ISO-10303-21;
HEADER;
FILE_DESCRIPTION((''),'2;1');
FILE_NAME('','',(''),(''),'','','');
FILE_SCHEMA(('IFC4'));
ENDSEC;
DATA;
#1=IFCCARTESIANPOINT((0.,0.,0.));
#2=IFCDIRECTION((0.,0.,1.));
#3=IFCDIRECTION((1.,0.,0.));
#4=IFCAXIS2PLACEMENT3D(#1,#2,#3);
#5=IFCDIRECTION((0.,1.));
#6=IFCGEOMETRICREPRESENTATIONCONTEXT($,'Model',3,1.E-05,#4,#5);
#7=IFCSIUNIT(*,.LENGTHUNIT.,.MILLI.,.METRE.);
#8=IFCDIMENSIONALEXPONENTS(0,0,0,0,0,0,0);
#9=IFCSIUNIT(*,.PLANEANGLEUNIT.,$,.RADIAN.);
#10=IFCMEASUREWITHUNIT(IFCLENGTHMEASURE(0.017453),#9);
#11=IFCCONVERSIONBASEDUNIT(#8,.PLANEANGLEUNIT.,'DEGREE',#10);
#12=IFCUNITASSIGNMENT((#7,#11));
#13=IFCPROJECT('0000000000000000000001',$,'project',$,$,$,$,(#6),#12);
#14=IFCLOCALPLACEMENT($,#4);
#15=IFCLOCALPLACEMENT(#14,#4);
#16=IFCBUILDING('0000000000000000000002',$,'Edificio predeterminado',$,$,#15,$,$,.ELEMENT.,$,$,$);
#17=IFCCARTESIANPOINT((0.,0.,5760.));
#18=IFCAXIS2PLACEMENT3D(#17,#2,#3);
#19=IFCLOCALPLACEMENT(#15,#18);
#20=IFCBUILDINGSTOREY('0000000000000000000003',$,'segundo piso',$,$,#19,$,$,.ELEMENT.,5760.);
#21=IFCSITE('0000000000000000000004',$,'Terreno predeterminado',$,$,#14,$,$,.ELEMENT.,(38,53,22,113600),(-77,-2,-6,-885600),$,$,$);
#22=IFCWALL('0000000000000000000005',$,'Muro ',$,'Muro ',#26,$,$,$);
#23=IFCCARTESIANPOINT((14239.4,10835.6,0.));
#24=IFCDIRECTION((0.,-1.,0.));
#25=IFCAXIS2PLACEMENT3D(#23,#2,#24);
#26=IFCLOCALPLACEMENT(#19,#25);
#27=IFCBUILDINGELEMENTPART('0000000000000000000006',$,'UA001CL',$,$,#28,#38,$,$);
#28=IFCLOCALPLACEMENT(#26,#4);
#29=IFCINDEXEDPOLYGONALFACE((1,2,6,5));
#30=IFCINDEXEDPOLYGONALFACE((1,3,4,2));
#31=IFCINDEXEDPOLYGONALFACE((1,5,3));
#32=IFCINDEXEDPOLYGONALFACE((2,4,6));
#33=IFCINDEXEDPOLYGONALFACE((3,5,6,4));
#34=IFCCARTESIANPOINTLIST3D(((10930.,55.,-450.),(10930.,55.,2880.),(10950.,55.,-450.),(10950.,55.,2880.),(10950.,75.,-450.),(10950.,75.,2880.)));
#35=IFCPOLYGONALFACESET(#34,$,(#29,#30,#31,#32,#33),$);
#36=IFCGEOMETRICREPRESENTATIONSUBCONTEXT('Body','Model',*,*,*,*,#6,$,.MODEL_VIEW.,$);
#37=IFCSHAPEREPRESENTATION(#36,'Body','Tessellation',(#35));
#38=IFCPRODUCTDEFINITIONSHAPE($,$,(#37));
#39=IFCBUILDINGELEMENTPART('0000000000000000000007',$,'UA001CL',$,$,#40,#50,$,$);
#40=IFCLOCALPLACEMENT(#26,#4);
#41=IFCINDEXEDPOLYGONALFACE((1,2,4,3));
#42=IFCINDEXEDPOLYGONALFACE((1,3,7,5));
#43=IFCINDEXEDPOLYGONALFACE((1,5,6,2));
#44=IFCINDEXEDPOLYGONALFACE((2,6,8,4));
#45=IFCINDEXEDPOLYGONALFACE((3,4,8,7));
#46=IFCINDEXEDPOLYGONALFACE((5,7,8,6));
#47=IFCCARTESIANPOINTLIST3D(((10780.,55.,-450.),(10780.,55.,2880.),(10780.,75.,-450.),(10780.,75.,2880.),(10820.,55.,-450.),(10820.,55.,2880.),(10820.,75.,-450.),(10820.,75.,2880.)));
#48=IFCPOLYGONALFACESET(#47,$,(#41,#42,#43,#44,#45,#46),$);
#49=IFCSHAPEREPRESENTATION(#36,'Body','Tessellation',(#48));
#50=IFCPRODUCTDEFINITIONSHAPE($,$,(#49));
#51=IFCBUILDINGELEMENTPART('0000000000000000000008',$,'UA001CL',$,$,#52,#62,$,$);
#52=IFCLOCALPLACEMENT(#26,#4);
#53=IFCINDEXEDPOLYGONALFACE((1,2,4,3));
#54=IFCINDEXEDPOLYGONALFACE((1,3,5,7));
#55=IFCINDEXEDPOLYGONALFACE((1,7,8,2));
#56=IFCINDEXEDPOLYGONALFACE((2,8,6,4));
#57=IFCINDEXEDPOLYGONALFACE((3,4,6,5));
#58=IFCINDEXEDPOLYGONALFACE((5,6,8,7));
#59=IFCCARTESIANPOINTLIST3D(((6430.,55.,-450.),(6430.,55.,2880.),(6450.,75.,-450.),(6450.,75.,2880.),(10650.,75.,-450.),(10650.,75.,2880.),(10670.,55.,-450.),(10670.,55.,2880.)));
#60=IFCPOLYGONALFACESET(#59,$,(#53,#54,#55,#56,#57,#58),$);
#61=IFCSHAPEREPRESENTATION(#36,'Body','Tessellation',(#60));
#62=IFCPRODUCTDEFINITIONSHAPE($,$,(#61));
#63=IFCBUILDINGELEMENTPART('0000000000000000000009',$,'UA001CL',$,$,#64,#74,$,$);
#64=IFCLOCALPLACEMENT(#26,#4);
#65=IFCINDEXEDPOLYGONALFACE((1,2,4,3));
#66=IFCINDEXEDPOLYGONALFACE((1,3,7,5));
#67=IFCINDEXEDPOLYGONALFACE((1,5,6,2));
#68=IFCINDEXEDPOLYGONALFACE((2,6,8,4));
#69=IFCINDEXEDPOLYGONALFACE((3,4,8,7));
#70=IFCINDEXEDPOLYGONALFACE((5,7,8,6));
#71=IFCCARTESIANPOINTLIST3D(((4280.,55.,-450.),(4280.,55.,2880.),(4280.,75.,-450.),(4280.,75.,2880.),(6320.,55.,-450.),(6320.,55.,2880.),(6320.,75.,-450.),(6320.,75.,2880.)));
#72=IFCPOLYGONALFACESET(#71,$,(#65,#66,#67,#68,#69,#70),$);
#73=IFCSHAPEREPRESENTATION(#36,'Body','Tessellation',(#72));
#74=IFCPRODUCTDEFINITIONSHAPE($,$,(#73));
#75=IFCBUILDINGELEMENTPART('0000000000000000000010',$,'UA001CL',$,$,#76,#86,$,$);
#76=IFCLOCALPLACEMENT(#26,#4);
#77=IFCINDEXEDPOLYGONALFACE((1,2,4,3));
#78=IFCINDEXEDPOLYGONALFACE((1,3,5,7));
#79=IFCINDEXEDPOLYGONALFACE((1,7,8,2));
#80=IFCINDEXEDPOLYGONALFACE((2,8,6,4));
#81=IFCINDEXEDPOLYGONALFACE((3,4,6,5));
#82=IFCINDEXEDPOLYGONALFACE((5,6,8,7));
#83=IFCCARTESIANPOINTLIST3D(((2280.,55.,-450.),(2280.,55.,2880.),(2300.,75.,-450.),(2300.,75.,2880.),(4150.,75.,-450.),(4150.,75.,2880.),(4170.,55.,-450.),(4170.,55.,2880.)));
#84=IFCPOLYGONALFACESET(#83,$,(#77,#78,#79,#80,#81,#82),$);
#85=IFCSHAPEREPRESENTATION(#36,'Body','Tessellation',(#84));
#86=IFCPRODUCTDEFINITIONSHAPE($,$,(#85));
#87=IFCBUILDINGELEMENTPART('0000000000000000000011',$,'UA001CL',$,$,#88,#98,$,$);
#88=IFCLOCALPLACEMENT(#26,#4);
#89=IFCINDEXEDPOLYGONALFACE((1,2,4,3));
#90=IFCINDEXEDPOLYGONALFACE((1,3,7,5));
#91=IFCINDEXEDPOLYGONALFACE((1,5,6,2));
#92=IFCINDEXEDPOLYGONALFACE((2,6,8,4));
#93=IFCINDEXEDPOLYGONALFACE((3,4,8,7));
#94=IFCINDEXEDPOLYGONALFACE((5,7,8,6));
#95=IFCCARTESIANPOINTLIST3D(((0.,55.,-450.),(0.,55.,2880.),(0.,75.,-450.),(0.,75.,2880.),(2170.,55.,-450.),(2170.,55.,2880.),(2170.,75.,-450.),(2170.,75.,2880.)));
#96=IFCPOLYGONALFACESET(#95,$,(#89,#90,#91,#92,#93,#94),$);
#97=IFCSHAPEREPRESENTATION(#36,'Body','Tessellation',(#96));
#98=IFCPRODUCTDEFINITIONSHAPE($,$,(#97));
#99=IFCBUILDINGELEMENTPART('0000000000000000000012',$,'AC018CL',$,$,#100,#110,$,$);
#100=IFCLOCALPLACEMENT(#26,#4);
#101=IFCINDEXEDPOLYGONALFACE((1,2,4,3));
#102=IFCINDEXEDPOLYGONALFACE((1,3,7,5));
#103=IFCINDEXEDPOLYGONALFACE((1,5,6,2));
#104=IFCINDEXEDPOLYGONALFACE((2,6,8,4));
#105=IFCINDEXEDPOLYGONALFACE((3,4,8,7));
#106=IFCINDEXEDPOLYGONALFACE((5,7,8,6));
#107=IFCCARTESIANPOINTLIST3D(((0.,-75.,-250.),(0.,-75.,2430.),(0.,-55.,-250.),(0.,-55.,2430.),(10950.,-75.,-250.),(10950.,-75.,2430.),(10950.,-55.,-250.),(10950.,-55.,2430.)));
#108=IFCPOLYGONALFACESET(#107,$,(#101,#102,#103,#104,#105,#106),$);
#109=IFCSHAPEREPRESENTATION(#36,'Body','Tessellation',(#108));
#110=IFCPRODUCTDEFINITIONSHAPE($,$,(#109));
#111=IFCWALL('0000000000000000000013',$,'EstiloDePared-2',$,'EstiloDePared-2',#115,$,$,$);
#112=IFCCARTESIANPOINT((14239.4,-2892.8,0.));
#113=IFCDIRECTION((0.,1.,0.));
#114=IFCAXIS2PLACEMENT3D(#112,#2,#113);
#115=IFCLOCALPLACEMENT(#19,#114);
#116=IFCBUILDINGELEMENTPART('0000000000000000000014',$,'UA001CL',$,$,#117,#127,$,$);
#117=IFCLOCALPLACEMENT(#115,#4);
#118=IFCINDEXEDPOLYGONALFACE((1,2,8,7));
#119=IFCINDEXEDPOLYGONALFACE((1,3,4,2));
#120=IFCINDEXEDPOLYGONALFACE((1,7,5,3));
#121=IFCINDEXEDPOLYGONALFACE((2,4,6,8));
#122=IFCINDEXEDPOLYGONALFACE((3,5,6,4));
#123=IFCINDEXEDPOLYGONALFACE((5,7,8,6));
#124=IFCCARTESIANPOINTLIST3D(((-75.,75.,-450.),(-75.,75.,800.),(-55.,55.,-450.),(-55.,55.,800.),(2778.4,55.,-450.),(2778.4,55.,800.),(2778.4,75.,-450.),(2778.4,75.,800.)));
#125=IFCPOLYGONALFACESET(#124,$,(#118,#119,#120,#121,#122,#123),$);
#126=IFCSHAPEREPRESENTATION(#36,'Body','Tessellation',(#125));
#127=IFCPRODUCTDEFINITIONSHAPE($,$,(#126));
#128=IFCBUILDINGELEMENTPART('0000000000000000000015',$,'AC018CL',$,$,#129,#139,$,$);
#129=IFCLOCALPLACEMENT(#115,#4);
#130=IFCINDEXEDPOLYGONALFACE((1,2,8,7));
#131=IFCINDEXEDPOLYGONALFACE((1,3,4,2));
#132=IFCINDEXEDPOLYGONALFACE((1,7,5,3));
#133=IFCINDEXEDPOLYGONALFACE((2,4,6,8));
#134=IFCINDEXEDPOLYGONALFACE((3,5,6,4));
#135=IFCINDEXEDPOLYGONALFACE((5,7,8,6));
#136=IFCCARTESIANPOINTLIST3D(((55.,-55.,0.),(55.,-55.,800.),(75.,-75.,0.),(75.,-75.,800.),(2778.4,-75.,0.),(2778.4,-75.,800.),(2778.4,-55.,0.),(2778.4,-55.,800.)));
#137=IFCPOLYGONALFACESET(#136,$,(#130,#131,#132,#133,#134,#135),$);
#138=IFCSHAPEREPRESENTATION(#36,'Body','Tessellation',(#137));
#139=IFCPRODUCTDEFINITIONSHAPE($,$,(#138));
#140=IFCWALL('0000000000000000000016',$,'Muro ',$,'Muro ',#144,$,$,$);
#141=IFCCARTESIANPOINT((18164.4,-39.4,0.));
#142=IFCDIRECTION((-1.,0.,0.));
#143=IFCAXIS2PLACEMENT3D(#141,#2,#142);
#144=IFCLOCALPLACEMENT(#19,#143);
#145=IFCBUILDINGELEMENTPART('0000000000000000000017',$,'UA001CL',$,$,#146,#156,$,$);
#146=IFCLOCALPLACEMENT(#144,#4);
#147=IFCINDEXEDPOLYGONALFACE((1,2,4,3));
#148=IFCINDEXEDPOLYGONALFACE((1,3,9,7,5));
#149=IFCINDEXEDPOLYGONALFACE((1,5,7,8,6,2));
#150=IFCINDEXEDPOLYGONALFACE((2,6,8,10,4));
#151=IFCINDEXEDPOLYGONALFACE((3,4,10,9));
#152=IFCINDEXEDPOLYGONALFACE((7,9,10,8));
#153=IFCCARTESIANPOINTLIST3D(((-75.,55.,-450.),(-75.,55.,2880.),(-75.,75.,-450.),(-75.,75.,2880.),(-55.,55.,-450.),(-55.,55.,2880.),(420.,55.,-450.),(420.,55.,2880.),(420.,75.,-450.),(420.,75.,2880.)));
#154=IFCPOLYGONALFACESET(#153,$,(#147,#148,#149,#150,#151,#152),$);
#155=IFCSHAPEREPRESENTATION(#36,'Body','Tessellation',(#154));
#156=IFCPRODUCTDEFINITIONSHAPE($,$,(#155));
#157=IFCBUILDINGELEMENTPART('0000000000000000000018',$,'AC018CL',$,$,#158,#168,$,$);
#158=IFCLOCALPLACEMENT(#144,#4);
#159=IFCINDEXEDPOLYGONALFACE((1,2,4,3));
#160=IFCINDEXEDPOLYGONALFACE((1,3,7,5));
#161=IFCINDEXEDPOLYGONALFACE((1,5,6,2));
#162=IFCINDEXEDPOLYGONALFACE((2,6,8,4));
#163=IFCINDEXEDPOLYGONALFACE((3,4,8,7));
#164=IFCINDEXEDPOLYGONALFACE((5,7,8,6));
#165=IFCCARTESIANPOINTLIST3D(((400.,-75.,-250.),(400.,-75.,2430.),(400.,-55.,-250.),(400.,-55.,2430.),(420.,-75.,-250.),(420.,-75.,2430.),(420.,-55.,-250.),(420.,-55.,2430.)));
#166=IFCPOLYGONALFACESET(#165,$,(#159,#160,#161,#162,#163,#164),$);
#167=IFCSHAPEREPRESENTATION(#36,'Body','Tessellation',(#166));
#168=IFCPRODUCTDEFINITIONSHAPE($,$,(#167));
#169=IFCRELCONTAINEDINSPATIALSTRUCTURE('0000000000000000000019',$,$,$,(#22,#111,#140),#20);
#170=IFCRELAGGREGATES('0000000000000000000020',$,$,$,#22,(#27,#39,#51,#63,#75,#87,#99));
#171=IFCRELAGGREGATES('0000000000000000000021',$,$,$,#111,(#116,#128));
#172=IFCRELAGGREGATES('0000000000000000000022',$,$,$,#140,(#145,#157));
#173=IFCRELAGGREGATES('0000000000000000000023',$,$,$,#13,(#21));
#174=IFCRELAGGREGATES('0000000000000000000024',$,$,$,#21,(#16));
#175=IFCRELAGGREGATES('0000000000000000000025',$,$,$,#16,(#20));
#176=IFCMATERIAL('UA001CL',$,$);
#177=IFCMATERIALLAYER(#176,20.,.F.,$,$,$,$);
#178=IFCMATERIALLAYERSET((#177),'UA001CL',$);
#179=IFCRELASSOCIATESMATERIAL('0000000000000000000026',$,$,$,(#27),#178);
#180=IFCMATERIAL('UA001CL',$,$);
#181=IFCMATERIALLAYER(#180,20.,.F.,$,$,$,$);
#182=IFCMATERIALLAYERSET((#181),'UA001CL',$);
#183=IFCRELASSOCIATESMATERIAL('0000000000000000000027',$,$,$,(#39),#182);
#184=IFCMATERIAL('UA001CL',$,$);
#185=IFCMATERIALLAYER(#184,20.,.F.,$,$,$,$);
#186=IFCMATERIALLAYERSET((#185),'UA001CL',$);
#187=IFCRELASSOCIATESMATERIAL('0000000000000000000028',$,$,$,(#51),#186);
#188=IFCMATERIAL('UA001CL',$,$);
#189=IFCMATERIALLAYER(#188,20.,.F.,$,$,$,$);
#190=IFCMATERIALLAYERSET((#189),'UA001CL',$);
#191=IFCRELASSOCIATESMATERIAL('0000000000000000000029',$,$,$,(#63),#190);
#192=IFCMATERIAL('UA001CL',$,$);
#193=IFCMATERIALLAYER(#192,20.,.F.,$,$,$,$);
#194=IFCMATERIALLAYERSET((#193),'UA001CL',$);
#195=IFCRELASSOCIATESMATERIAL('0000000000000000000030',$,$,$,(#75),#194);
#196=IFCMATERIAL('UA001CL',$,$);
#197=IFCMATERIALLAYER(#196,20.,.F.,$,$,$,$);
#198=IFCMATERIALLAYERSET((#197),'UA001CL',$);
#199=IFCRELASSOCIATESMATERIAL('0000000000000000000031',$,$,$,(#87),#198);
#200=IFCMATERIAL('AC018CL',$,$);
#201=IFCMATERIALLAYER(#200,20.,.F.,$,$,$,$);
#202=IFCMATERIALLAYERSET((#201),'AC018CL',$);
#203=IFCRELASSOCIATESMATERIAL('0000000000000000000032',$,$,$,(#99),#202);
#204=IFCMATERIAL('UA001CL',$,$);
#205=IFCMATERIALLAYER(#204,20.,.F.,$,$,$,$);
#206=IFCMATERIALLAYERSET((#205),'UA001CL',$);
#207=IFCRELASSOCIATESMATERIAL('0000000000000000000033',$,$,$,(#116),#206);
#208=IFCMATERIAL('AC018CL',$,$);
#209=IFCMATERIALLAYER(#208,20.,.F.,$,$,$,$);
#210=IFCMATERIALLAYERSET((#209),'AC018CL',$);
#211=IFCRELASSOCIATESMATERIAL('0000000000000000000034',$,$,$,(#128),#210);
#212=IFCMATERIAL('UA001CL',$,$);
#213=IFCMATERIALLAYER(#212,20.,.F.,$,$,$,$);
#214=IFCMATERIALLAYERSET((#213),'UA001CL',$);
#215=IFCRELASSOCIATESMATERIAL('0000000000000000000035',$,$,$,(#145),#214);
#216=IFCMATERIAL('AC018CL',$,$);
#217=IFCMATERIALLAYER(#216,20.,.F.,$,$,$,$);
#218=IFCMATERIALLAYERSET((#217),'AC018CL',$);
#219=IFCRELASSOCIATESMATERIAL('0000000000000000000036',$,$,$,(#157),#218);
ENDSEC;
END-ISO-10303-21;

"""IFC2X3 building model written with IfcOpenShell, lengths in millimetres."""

from ifc_helpers import new_model, entity, si_unit, converted_unit, direction, frame, origin_with_axes, place, context, subcontext, project, spatial, polyline, outline, extrude, material, layer, layer_set, layer_usage, element, aggregate, save


model = new_model("IFC2X3")

# Units and contexts
model_context = context("Model", 3, precision=1e-05, world=origin_with_axes(), true_north=direction((0.0, 1.0)))
body_context = subcontext(model_context, "Body", "Model", "MODEL_VIEW")
ifc_project = project(units=[si_unit("LENGTHUNIT", "METRE", prefix="MILLI"), converted_unit("PLANEANGLEUNIT", "DEGREE", entity("IfcLengthMeasure", 0.017453), si_unit("PLANEANGLEUNIT", "RADIAN"), dimensions=[0, 0, 0, 0, 0, 0, 0])], contexts=[model_context])

# Site, building, storey
site_placement = place(None, origin_with_axes())
site = spatial("IfcSite", under=ifc_project, at=site_placement, Name="Terreno predeterminado", CompositionType="ELEMENT", RefLatitude=(38, 53, 22, 113600), RefLongitude=(-77, -2, -6, -885600))
building_placement = place(site_placement, origin_with_axes())
building = spatial("IfcBuilding", under=site, at=building_placement, Name="Edificio predeterminado", CompositionType="ELEMENT")
storey_placement = place(building_placement, frame((0.0, 0.0, 5760.0), z_axis=(0.0, 0.0, 1.0), x_axis=(1.0, 0.0, 0.0)))
storey = spatial("IfcBuildingStorey", under=building, at=storey_placement, Name="segundo piso", CompositionType="ELEMENT", Elevation=5760.0)

# Walls, building element parts
wall_1_placement = place(storey_placement, frame((14239.4, 10835.6, 0.0), z_axis=(0.0, 0.0, 1.0), x_axis=(0.0, -1.0, 0.0)))
wall_1 = element("IfcWall", 1, at=wall_1_placement, inside=storey, Name="Muro ", ObjectType="Muro ")
ifc_material_1 = material(Name="UA001CL")
ifc_layer_1 = layer(ifc_material_1, 20.0, ventilated=False)
ifc_layer_set_1 = layer_set([ifc_layer_1], Name="UA001CL")
ifc_layer_usage_1 = layer_usage(ifc_layer_set_1, "AXIS2", "NEGATIVE", -75.0)
building_element_part_1_placement = place(wall_1_placement, origin_with_axes())
building_element_part_1 = element("IfcBuildingElementPart", 2, at=building_element_part_1_placement, material=ifc_layer_usage_1, Name="UA001CL", context=body_context, shape_type="SweptSolid", body=[
    extrude(outline(polyline([(10950.0, 75.0), (10950.0, 55.0), (10930.0, 55.0), (10950.0, 75.0)])), frame((0.0, 0.0, -450.0), z_axis=(0.0, 0.0, 1.0), x_axis=(1.0, 0.0, 0.0)), (0.0, 0.0, 1.0), 3330.0),
])
ifc_material_2 = material(Name="UA001CL")
ifc_layer_2 = layer(ifc_material_2, 20.0, ventilated=False)
ifc_layer_set_2 = layer_set([ifc_layer_2], Name="UA001CL")
ifc_layer_usage_2 = layer_usage(ifc_layer_set_2, "AXIS2", "NEGATIVE", -75.0)
building_element_part_2_placement = place(wall_1_placement, origin_with_axes())
building_element_part_2 = element("IfcBuildingElementPart", 3, at=building_element_part_2_placement, material=ifc_layer_usage_2, Name="UA001CL", context=body_context, shape_type="SweptSolid", body=[
    extrude(outline(polyline([(10820.0, 75.0), (10820.0, 55.0), (10780.0, 55.0), (10780.0, 75.0), (10820.0, 75.0)])), frame((0.0, 0.0, -450.0), z_axis=(0.0, 0.0, 1.0), x_axis=(1.0, 0.0, 0.0)), (0.0, 0.0, 1.0), 3330.0),
])
ifc_material_3 = material(Name="UA001CL")
ifc_layer_3 = layer(ifc_material_3, 20.0, ventilated=False)
ifc_layer_set_3 = layer_set([ifc_layer_3], Name="UA001CL")
ifc_layer_usage_3 = layer_usage(ifc_layer_set_3, "AXIS2", "NEGATIVE", -75.0)
building_element_part_3_placement = place(wall_1_placement, origin_with_axes())
building_element_part_3 = element("IfcBuildingElementPart", 4, at=building_element_part_3_placement, material=ifc_layer_usage_3, Name="UA001CL", context=body_context, shape_type="SweptSolid", body=[
    extrude(outline(polyline([(10650.0, 75.0), (10670.0, 55.0), (6430.0, 55.0), (6450.0, 75.0), (10650.0, 75.0)])), frame((0.0, 0.0, -450.0), z_axis=(0.0, 0.0, 1.0), x_axis=(1.0, 0.0, 0.0)), (0.0, 0.0, 1.0), 3330.0),
])
ifc_material_4 = material(Name="UA001CL")
ifc_layer_4 = layer(ifc_material_4, 20.0, ventilated=False)
ifc_layer_set_4 = layer_set([ifc_layer_4], Name="UA001CL")
ifc_layer_usage_4 = layer_usage(ifc_layer_set_4, "AXIS2", "NEGATIVE", -75.0)
building_element_part_4_placement = place(wall_1_placement, origin_with_axes())
building_element_part_4 = element("IfcBuildingElementPart", 5, at=building_element_part_4_placement, material=ifc_layer_usage_4, Name="UA001CL", context=body_context, shape_type="SweptSolid", body=[
    extrude(outline(polyline([(4280.0, 75.0), (6320.0, 75.0), (6320.0, 55.0), (4280.0, 55.0), (4280.0, 75.0)])), frame((0.0, 0.0, -450.0), z_axis=(0.0, 0.0, 1.0), x_axis=(1.0, 0.0, 0.0)), (0.0, 0.0, 1.0), 3330.0),
])
ifc_material_5 = material(Name="UA001CL")
ifc_layer_5 = layer(ifc_material_5, 20.0, ventilated=False)
ifc_layer_set_5 = layer_set([ifc_layer_5], Name="UA001CL")
ifc_layer_usage_5 = layer_usage(ifc_layer_set_5, "AXIS2", "NEGATIVE", -75.0)
building_element_part_5_placement = place(wall_1_placement, origin_with_axes())
building_element_part_5 = element("IfcBuildingElementPart", 6, at=building_element_part_5_placement, material=ifc_layer_usage_5, Name="UA001CL", context=body_context, shape_type="SweptSolid", body=[
    extrude(outline(polyline([(4150.0, 75.0), (4170.0, 55.0), (2280.0, 55.0), (2300.0, 75.0), (4150.0, 75.0)])), frame((0.0, 0.0, -450.0), z_axis=(0.0, 0.0, 1.0), x_axis=(1.0, 0.0, 0.0)), (0.0, 0.0, 1.0), 3330.0),
])
ifc_material_6 = material(Name="UA001CL")
ifc_layer_6 = layer(ifc_material_6, 20.0, ventilated=False)
ifc_layer_set_6 = layer_set([ifc_layer_6], Name="UA001CL")
ifc_layer_usage_6 = layer_usage(ifc_layer_set_6, "AXIS2", "NEGATIVE", -75.0)
building_element_part_6_placement = place(wall_1_placement, origin_with_axes())
building_element_part_6 = element("IfcBuildingElementPart", 7, at=building_element_part_6_placement, material=ifc_layer_usage_6, Name="UA001CL", context=body_context, shape_type="SweptSolid", body=[
    extrude(outline(polyline([(2170.0, 75.0), (2170.0, 55.0), (0.0, 55.0), (0.0, 75.0), (2170.0, 75.0)])), frame((0.0, 0.0, -450.0), z_axis=(0.0, 0.0, 1.0), x_axis=(1.0, 0.0, 0.0)), (0.0, 0.0, 1.0), 3330.0),
])
ifc_material_7 = material(Name="AC018CL")
ifc_layer_7 = layer(ifc_material_7, 20.0, ventilated=False)
ifc_layer_set_7 = layer_set([ifc_layer_7], Name="AC018CL")
ifc_layer_usage_7 = layer_usage(ifc_layer_set_7, "AXIS2", "NEGATIVE", 55.0)
building_element_part_7_placement = place(wall_1_placement, origin_with_axes())
building_element_part_7 = element("IfcBuildingElementPart", 8, at=building_element_part_7_placement, material=ifc_layer_usage_7, Name="AC018CL", context=body_context, shape_type="SweptSolid", body=[
    extrude(outline(polyline([(10950.0, -55.0), (10950.0, -75.0), (0.0, -75.0), (0.0, -55.0), (10950.0, -55.0)])), frame((0.0, 0.0, -250.0), z_axis=(0.0, 0.0, 1.0), x_axis=(1.0, 0.0, 0.0)), (0.0, 0.0, 1.0), 2680.0),
])
aggregate(wall_1, [building_element_part_1, building_element_part_2, building_element_part_3, building_element_part_4, building_element_part_5, building_element_part_6, building_element_part_7])
wall_2_placement = place(storey_placement, frame((14239.4, -2892.8, 0.0), z_axis=(0.0, 0.0, 1.0), x_axis=(0.0, 1.0, 0.0)))
wall_2 = element("IfcWall", 9, at=wall_2_placement, inside=storey, Name="EstiloDePared-2", ObjectType="EstiloDePared-2")
ifc_material_8 = material(Name="UA001CL")
ifc_layer_8 = layer(ifc_material_8, 20.0, ventilated=False)
ifc_layer_set_8 = layer_set([ifc_layer_8], Name="UA001CL")
ifc_layer_usage_8 = layer_usage(ifc_layer_set_8, "AXIS2", "NEGATIVE", -75.0)
building_element_part_8_placement = place(wall_2_placement, origin_with_axes())
building_element_part_8 = element("IfcBuildingElementPart", 10, at=building_element_part_8_placement, material=ifc_layer_usage_8, Name="UA001CL", context=body_context, shape_type="SweptSolid", body=[
    extrude(outline(polyline([(2778.4, 75.0), (2778.4, 55.0), (-55.0, 55.0), (-75.0, 75.0), (2778.4, 75.0)])), frame((0.0, 0.0, -450.0), z_axis=(0.0, 0.0, 1.0), x_axis=(1.0, 0.0, 0.0)), (0.0, 0.0, 1.0), 1250.0),
])
ifc_material_9 = material(Name="AC018CL")
ifc_layer_9 = layer(ifc_material_9, 20.0, ventilated=False)
ifc_layer_set_9 = layer_set([ifc_layer_9], Name="AC018CL")
ifc_layer_usage_9 = layer_usage(ifc_layer_set_9, "AXIS2", "NEGATIVE", 55.0)
building_element_part_9_placement = place(wall_2_placement, origin_with_axes())
building_element_part_9 = element("IfcBuildingElementPart", 11, at=building_element_part_9_placement, material=ifc_layer_usage_9, Name="AC018CL", context=body_context, shape_type="SweptSolid", body=[
    extrude(outline(polyline([(2778.4, -55.0), (2778.4, -75.0), (75.0, -75.0), (55.0, -55.0), (2778.4, -55.0)])), origin_with_axes(), (0.0, 0.0, 1.0), 800.0),
])
aggregate(wall_2, [building_element_part_8, building_element_part_9])
wall_3_placement = place(storey_placement, frame((18164.4, -39.4, 0.0), z_axis=(0.0, 0.0, 1.0), x_axis=(-1.0, 0.0, 0.0)))
wall_3 = element("IfcWall", 12, at=wall_3_placement, inside=storey, Name="Muro ", ObjectType="Muro ")
ifc_material_10 = material(Name="UA001CL")
ifc_layer_10 = layer(ifc_material_10, 20.0, ventilated=False)
ifc_layer_set_10 = layer_set([ifc_layer_10], Name="UA001CL")
ifc_layer_usage_10 = layer_usage(ifc_layer_set_10, "AXIS2", "NEGATIVE", -75.0)
building_element_part_10_placement = place(wall_3_placement, origin_with_axes())
building_element_part_10 = element("IfcBuildingElementPart", 13, at=building_element_part_10_placement, material=ifc_layer_usage_10, Name="UA001CL", context=body_context, shape_type="SweptSolid", body=[
    extrude(outline(polyline([(420.0, 75.0), (420.0, 55.0), (-55.0, 55.0), (-75.0, 55.0), (-75.0, 75.0), (420.0, 75.0)])), frame((0.0, 0.0, -450.0), z_axis=(0.0, 0.0, 1.0), x_axis=(1.0, 0.0, 0.0)), (0.0, 0.0, 1.0), 3330.0),
])
ifc_material_11 = material(Name="AC018CL")
ifc_layer_11 = layer(ifc_material_11, 20.0, ventilated=False)
ifc_layer_set_11 = layer_set([ifc_layer_11], Name="AC018CL")
ifc_layer_usage_11 = layer_usage(ifc_layer_set_11, "AXIS2", "NEGATIVE", 55.0)
building_element_part_11_placement = place(wall_3_placement, origin_with_axes())
building_element_part_11 = element("IfcBuildingElementPart", 14, at=building_element_part_11_placement, material=ifc_layer_usage_11, Name="AC018CL", context=body_context, shape_type="SweptSolid", body=[
    extrude(outline(polyline([(420.0, -55.0), (420.0, -75.0), (400.0, -75.0), (400.0, -55.0), (420.0, -55.0)])), frame((0.0, 0.0, -250.0), z_axis=(0.0, 0.0, 1.0), x_axis=(1.0, 0.0, 0.0)), (0.0, 0.0, 1.0), 2680.0),
])
aggregate(wall_3, [building_element_part_10, building_element_part_11])

save(model, "model.ifc")
